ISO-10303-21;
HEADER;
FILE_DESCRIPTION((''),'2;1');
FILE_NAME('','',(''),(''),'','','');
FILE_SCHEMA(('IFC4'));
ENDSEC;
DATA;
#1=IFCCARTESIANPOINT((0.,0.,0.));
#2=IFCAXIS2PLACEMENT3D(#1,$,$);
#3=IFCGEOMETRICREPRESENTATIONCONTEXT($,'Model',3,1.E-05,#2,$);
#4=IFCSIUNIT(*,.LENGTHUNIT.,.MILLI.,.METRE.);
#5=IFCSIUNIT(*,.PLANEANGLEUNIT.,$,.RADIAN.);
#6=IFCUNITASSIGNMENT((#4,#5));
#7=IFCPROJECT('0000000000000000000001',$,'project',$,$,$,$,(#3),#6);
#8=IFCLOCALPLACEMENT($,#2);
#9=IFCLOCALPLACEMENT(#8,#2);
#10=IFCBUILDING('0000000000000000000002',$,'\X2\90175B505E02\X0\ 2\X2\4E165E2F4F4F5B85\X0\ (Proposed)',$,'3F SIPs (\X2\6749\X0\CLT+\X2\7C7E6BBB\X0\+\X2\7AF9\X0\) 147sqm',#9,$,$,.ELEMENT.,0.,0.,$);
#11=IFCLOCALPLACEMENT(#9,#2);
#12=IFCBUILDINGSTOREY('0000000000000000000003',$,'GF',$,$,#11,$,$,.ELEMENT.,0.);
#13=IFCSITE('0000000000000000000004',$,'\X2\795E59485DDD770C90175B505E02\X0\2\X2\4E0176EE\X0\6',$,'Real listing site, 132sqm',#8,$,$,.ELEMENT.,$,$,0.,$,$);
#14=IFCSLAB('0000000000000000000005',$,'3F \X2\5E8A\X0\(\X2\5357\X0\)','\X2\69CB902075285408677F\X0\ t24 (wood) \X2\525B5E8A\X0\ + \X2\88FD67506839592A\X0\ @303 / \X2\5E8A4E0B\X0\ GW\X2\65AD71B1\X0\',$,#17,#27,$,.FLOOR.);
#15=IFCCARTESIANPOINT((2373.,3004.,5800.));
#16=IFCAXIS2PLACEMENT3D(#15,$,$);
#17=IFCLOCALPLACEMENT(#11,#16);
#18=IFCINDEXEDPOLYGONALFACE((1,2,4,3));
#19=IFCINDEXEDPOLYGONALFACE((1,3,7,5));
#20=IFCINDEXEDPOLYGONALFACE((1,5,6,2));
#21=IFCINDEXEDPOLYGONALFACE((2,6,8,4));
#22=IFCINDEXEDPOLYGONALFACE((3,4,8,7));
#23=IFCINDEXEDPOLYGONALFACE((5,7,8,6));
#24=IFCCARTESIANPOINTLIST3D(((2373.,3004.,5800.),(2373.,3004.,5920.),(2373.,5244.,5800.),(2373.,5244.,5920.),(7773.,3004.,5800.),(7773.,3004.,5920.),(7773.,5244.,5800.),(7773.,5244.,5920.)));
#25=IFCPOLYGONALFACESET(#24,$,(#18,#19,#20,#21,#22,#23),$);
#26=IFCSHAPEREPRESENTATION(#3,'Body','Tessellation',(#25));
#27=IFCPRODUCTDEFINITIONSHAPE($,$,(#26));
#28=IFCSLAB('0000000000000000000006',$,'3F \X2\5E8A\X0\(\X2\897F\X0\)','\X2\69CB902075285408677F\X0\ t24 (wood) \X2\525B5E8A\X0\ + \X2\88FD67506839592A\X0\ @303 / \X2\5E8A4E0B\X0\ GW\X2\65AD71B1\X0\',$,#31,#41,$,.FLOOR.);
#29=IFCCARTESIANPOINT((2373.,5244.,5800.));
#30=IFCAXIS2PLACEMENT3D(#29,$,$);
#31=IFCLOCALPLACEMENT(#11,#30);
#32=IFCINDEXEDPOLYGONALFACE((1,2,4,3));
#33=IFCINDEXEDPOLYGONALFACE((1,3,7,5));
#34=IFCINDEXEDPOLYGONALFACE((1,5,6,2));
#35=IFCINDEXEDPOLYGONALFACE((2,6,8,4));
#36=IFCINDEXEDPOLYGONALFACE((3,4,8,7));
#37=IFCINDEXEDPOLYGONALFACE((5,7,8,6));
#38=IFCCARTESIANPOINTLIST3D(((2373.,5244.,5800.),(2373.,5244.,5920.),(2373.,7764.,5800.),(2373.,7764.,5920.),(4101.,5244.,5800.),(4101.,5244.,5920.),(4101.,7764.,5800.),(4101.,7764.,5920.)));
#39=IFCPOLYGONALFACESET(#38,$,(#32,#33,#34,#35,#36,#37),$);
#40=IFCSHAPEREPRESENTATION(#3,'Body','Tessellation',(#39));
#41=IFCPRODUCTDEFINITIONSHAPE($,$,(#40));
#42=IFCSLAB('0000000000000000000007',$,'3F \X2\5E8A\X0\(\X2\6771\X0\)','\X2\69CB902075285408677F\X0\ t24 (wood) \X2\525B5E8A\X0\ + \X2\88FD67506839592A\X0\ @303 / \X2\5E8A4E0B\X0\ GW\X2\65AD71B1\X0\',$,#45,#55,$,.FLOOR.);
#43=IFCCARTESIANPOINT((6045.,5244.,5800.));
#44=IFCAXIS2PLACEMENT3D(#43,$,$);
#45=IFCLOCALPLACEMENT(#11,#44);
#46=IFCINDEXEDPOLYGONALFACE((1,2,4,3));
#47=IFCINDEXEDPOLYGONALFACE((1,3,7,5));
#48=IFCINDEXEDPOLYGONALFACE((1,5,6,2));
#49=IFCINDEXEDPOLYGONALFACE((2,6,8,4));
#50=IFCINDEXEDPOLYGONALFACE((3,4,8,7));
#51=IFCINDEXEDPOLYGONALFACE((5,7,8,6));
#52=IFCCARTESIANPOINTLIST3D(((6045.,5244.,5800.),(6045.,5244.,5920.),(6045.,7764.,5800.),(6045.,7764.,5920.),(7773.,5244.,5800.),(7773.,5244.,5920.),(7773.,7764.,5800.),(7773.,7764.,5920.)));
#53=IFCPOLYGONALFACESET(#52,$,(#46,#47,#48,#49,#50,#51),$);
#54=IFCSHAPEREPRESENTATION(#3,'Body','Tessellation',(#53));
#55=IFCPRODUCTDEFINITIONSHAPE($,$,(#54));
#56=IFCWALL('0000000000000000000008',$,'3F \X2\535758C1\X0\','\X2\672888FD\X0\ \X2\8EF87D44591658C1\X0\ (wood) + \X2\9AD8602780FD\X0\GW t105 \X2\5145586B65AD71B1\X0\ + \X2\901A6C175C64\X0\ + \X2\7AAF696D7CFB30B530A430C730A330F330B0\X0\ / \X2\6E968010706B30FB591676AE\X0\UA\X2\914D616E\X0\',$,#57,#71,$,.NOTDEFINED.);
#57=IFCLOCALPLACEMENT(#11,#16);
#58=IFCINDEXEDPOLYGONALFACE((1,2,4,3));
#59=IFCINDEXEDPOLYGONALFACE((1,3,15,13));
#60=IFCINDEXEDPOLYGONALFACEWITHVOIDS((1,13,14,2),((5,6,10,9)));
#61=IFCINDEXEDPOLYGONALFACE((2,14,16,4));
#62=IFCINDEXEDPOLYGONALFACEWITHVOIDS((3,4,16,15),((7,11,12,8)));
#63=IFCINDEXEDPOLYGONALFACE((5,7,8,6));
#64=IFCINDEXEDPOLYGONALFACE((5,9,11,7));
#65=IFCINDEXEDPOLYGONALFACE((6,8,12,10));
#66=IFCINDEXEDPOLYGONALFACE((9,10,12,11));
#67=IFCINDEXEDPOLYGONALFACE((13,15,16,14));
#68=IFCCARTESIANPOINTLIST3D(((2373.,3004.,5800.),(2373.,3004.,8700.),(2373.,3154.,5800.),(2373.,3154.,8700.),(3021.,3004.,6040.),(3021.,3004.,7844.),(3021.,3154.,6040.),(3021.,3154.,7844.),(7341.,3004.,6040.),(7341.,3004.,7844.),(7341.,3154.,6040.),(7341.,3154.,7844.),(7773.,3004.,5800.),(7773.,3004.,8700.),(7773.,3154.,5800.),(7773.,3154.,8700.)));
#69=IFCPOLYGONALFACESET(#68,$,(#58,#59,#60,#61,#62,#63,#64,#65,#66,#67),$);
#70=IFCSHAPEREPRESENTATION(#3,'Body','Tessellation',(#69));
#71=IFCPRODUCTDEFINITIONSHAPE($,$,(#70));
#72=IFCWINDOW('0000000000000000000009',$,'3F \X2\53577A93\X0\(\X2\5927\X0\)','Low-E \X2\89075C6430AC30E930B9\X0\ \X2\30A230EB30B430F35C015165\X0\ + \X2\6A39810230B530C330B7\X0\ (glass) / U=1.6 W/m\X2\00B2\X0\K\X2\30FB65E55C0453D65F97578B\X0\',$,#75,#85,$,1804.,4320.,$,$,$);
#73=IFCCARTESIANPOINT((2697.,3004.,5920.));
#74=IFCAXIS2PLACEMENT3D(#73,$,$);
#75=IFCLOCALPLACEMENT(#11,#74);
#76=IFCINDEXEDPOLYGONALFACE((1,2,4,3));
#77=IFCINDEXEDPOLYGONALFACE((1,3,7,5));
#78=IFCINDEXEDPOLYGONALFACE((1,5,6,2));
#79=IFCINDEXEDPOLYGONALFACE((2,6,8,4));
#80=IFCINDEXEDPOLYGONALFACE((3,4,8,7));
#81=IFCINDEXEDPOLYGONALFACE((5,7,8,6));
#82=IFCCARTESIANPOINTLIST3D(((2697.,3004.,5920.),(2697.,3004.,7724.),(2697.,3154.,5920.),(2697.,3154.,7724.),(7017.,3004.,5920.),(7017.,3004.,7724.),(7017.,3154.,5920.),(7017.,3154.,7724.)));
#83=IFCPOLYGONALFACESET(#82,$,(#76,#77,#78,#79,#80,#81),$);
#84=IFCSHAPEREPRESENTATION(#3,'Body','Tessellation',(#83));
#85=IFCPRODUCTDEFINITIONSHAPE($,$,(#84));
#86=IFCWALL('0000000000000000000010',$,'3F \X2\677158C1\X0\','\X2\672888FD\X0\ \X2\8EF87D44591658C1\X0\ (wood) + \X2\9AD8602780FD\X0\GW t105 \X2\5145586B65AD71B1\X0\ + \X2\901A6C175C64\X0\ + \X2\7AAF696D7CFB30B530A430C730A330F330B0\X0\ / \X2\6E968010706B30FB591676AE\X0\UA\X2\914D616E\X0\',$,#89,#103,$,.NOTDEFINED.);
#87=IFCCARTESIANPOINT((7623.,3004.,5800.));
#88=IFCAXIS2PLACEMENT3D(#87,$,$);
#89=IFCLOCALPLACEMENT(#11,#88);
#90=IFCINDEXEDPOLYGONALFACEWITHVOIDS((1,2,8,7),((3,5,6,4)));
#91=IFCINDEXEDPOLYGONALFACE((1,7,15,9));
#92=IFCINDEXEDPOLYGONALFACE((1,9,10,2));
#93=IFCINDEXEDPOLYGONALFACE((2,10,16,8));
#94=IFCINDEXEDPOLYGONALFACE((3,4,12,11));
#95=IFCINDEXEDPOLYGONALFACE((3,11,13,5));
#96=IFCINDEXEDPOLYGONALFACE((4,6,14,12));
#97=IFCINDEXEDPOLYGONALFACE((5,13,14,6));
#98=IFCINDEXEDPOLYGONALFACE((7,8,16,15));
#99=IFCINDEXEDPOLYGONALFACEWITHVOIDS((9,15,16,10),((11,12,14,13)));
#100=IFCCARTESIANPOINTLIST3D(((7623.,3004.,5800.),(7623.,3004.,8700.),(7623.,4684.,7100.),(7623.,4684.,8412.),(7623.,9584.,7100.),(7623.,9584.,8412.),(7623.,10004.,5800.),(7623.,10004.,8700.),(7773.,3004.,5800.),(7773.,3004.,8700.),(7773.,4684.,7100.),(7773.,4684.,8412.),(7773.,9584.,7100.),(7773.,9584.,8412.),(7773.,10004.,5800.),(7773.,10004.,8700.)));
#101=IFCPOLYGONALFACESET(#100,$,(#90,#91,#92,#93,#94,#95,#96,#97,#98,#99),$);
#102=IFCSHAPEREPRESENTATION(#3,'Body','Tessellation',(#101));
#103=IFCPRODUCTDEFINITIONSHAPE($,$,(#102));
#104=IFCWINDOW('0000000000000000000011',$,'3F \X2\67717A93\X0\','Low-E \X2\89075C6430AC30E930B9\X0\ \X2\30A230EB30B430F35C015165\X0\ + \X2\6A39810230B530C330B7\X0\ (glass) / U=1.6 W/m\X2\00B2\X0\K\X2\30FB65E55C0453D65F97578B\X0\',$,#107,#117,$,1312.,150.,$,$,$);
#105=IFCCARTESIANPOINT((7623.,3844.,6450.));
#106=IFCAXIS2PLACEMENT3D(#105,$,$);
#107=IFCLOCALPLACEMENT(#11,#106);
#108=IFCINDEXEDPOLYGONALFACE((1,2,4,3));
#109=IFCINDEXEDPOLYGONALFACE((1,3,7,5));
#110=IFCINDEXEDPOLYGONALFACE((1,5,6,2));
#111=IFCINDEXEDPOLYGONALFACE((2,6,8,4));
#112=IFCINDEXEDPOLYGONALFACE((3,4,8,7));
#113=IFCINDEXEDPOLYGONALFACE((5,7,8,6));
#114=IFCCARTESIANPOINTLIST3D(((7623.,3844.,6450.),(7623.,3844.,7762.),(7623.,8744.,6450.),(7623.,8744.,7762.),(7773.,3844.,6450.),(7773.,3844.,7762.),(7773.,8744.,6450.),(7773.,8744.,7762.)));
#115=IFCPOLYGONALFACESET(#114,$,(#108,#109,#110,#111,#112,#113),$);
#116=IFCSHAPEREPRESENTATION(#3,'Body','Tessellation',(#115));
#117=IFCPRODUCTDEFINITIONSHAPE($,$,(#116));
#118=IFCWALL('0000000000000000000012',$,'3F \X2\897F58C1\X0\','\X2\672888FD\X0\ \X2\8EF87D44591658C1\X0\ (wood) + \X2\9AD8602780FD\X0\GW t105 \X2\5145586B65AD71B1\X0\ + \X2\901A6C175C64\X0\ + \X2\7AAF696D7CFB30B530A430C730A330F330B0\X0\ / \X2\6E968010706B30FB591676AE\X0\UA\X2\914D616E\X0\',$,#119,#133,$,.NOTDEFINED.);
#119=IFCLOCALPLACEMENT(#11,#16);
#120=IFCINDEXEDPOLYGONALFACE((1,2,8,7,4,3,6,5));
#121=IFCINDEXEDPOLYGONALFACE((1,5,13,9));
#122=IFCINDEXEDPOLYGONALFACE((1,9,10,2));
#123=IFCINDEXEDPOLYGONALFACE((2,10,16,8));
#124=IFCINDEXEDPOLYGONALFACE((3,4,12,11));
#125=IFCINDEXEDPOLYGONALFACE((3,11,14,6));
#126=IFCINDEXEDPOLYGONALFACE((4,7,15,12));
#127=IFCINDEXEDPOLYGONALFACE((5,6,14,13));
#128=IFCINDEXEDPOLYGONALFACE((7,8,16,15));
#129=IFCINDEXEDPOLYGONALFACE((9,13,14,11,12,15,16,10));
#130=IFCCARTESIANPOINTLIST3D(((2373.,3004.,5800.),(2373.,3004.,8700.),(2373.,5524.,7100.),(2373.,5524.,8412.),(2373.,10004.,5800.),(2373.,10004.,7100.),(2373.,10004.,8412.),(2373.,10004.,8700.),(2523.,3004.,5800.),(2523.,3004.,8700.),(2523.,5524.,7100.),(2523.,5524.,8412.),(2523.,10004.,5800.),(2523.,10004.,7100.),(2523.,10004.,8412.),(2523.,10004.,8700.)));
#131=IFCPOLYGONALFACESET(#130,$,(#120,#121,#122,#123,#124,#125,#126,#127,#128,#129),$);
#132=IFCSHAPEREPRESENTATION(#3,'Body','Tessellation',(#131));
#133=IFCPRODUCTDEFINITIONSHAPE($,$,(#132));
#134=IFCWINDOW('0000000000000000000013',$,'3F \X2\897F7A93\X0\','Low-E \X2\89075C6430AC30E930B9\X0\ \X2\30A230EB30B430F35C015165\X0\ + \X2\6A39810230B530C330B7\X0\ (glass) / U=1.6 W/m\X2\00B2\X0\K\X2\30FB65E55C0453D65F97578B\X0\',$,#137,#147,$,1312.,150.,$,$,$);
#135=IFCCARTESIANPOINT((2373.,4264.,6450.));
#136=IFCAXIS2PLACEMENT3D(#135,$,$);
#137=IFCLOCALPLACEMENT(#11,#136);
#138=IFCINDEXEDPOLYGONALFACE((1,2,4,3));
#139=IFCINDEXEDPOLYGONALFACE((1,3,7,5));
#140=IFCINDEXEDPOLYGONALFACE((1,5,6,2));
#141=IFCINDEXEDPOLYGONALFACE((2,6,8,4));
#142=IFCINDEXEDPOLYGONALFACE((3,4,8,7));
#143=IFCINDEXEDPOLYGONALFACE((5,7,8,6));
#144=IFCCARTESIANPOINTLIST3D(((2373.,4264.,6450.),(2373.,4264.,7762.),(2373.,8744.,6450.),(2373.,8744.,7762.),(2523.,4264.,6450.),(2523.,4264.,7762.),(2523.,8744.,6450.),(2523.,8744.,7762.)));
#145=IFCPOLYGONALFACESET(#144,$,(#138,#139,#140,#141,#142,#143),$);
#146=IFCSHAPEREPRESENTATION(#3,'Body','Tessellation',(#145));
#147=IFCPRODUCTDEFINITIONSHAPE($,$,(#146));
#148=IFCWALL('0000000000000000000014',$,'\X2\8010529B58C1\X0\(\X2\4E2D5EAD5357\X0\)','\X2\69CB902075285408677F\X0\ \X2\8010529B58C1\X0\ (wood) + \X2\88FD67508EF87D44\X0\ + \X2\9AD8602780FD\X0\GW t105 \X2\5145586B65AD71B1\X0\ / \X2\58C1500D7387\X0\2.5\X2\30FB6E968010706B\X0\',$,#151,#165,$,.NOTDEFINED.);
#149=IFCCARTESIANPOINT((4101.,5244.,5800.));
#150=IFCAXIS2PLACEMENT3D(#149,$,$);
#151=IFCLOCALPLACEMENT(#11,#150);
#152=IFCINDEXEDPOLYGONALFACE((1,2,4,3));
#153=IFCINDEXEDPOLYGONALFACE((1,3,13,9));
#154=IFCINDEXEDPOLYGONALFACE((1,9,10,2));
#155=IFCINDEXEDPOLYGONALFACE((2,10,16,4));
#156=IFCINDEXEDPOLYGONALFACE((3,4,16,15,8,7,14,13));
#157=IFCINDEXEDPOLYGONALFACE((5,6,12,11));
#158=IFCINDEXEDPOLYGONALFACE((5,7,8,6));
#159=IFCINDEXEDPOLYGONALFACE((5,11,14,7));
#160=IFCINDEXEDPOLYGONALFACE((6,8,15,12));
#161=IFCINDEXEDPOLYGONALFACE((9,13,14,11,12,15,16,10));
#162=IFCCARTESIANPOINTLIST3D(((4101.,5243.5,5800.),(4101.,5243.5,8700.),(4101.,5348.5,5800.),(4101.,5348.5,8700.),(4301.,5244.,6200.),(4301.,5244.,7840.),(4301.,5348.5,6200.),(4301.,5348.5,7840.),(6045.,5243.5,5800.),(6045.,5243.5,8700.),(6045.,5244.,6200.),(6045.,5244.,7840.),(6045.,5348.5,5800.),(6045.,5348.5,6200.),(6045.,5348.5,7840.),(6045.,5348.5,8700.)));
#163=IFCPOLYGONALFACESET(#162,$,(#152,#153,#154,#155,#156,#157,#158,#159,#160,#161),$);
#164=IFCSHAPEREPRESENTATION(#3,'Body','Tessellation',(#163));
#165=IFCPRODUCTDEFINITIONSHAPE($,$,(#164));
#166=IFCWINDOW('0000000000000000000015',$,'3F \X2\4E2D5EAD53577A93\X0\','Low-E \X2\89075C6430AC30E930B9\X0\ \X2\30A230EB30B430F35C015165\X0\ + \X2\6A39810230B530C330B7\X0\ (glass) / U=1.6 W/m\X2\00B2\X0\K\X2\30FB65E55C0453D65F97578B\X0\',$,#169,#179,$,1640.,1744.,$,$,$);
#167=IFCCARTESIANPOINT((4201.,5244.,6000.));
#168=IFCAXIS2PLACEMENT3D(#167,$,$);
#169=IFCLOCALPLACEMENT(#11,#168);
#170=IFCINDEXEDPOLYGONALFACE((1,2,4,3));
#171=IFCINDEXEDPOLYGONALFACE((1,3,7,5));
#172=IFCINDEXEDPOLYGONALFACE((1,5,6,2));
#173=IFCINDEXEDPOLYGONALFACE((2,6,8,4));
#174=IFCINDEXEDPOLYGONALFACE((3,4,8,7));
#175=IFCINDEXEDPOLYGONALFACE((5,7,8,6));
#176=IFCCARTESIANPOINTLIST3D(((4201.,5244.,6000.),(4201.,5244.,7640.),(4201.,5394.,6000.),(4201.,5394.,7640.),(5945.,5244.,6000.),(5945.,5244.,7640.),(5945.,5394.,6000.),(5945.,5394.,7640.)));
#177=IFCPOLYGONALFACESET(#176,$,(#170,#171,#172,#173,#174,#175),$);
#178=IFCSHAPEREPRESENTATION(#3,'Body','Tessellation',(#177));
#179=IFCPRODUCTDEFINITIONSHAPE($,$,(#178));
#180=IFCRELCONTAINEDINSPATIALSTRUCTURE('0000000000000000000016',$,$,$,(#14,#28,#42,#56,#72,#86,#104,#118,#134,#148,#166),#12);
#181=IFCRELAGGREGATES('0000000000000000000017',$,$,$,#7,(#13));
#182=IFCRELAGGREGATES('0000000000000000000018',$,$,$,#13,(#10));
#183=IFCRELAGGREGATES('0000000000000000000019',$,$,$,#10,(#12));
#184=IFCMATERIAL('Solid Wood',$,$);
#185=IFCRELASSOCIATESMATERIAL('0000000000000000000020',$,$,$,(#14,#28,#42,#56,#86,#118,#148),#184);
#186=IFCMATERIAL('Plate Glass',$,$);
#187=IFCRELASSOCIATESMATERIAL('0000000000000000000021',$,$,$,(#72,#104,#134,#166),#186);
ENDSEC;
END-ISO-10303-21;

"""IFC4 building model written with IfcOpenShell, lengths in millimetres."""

from ifc_helpers import new_model, si_unit, frame, frame_2d, origin, place, context, project, spatial, rectangle, extrude, material, element, fill, save


model = new_model("IFC4")

# Units and contexts
model_context = context("Model", 3, precision=1e-05, world=origin())
ifc_project = project(units=[si_unit("LENGTHUNIT", "METRE", prefix="MILLI"), si_unit("PLANEANGLEUNIT", "RADIAN")], contexts=[model_context])

# Site, building, storey
site_placement = place(None, origin())
site = spatial("IfcSite", under=ifc_project, at=site_placement, Name="神奈川県逗子市2丁目6", ObjectType="Real listing site, 132sqm", CompositionType="ELEMENT", RefElevation=0.0)
building_placement = place(site_placement, origin())
building = spatial("IfcBuilding", under=site, at=building_placement, Name="逗子市 2世帯住宅 (Proposed)", ObjectType="3F SIPs (杉CLT+籾殻+竹) 147sqm", CompositionType="ELEMENT", ElevationOfRefHeight=0.0, ElevationOfTerrain=0.0)
storey_placement = place(building_placement, origin())
storey = spatial("IfcBuildingStorey", under=building, at=storey_placement, Name="GF", CompositionType="ELEMENT", Elevation=0.0)

# Slabs
ifc_material_1 = material(Name="Solid Wood")
slab_1_placement = place(storey_placement, frame((2373.0, 3004.0, 5800.0)))
element("IfcSlab", 1, at=slab_1_placement, inside=storey, material=ifc_material_1, Name="3F 床(南)", Description="構造用合板 t24 (wood) 剛床 + 製材根太 @303 / 床下 GW断熱", PredefinedType="FLOOR", context=model_context, shape_type="SweptSolid", body=[
    extrude(rectangle(XDim=5400.0, YDim=2240.0, at=frame_2d((2700.0, 1120.0))), frame((2373.0, 3004.0, 5800.0)), (0.0, 0.0, 1.0), 120.0),
])
slab_2_placement = place(storey_placement, frame((2373.0, 5244.0, 5800.0)))
element("IfcSlab", 2, at=slab_2_placement, inside=storey, material=ifc_material_1, Name="3F 床(西)", Description="構造用合板 t24 (wood) 剛床 + 製材根太 @303 / 床下 GW断熱", PredefinedType="FLOOR", context=model_context, shape_type="SweptSolid", body=[
    extrude(rectangle(XDim=1728.0, YDim=2520.0, at=frame_2d((864.0, 1260.0))), frame((2373.0, 5244.0, 5800.0)), (0.0, 0.0, 1.0), 120.0),
])
slab_3_placement = place(storey_placement, frame((6045.0, 5244.0, 5800.0)))
element("IfcSlab", 3, at=slab_3_placement, inside=storey, material=ifc_material_1, Name="3F 床(東)", Description="構造用合板 t24 (wood) 剛床 + 製材根太 @303 / 床下 GW断熱", PredefinedType="FLOOR", context=model_context, shape_type="SweptSolid", body=[
    extrude(rectangle(XDim=1728.0, YDim=2520.0, at=frame_2d((864.0, 1260.0))), frame((6045.0, 5244.0, 5800.0)), (0.0, 0.0, 1.0), 120.0),
])

# Walls, openings, windows
wall_1_placement = place(storey_placement, frame((2373.0, 3004.0, 5800.0)))
wall_1 = element("IfcWall", 4, at=wall_1_placement, inside=storey, material=ifc_material_1, Name="3F 南壁", Description="木製 軸組外壁 (wood) + 高性能GW t105 充填断熱 + 通気層 + 窯業系サイディング / 準耐火・外皮UA配慮", PredefinedType="NOTDEFINED", context=model_context, shape_type="SweptSolid", body=[
    extrude(rectangle(XDim=5400.0, YDim=150.0, at=frame_2d((2700.0, 75.0))), frame((2373.0, 3004.0, 5800.0)), (0.0, 0.0, 1.0), 2900.0),
])
opening_1_placement = place(storey_placement, frame((2697.0, 3004.0, 5920.0)))
opening_1 = element("IfcOpeningElement", 5, at=opening_1_placement, cuts=wall_1, PredefinedType="NOTDEFINED", context=model_context, shape_type="SweptSolid", body=[
    extrude(rectangle(XDim=4320.0, YDim=150.0, at=frame_2d((2160.0, 75.0))), frame((2697.0, 3004.0, 5920.0)), (0.0, 0.0, 1.0), 1804.0),
])
ifc_material_2 = material(Name="Plate Glass")
window_1_placement = place(storey_placement, frame((2697.0, 3004.0, 5920.0)))
window_1 = element("IfcWindow", 6, at=window_1_placement, inside=storey, material=ifc_material_2, Name="3F 南窓(大)", Description="Low-E 複層ガラス アルゴン封入 + 樹脂サッシ (glass) / U=1.6 W/m²K・日射取得型", OverallHeight=1804.0, OverallWidth=4320.0, context=model_context, shape_type="SweptSolid", body=[
    extrude(rectangle(XDim=4320.0, YDim=150.0, at=frame_2d((2160.0, 75.0))), frame((2697.0, 3004.0, 5920.0)), (0.0, 0.0, 1.0), 1804.0),
])
fill(opening_1, window_1)
wall_2_placement = place(storey_placement, frame((7623.0, 3004.0, 5800.0)))
wall_2 = element("IfcWall", 7, at=wall_2_placement, inside=storey, material=ifc_material_1, Name="3F 東壁", Description="木製 軸組外壁 (wood) + 高性能GW t105 充填断熱 + 通気層 + 窯業系サイディング / 準耐火・外皮UA配慮", PredefinedType="NOTDEFINED", context=model_context, shape_type="SweptSolid", body=[
    extrude(rectangle(XDim=150.0, YDim=7000.0, at=frame_2d((75.0, 3500.0))), frame((7623.0, 3004.0, 5800.0)), (0.0, 0.0, 1.0), 2900.0),
])
opening_2_placement = place(storey_placement, frame((7623.0, 3844.0, 6450.0)))
opening_2 = element("IfcOpeningElement", 8, at=opening_2_placement, cuts=wall_2, PredefinedType="NOTDEFINED", context=model_context, shape_type="SweptSolid", body=[
    extrude(rectangle(XDim=150.0, YDim=4900.0, at=frame_2d((75.0, 2450.0))), frame((7623.0, 3844.0, 6450.0)), (0.0, 0.0, 1.0), 1312.0),
])
window_2_placement = place(storey_placement, frame((7623.0, 3844.0, 6450.0)))
window_2 = element("IfcWindow", 9, at=window_2_placement, inside=storey, material=ifc_material_2, Name="3F 東窓", Description="Low-E 複層ガラス アルゴン封入 + 樹脂サッシ (glass) / U=1.6 W/m²K・日射取得型", OverallHeight=1312.0, OverallWidth=150.0, context=model_context, shape_type="SweptSolid", body=[
    extrude(rectangle(XDim=150.0, YDim=4900.0, at=frame_2d((75.0, 2450.0))), frame((7623.0, 3844.0, 6450.0)), (0.0, 0.0, 1.0), 1312.0),
])
fill(opening_2, window_2)
wall_3_placement = place(storey_placement, frame((2373.0, 3004.0, 5800.0)))
wall_3 = element("IfcWall", 10, at=wall_3_placement, inside=storey, material=ifc_material_1, Name="3F 西壁", Description="木製 軸組外壁 (wood) + 高性能GW t105 充填断熱 + 通気層 + 窯業系サイディング / 準耐火・外皮UA配慮", PredefinedType="NOTDEFINED", context=model_context, shape_type="SweptSolid", body=[
    extrude(rectangle(XDim=150.0, YDim=7000.0, at=frame_2d((75.0, 3500.0))), frame((2373.0, 3004.0, 5800.0)), (0.0, 0.0, 1.0), 2900.0),
])
opening_3_placement = place(storey_placement, frame((2373.0, 4264.0, 6450.0)))
opening_3 = element("IfcOpeningElement", 11, at=opening_3_placement, cuts=wall_3, PredefinedType="NOTDEFINED", context=model_context, shape_type="SweptSolid", body=[
    extrude(rectangle(XDim=150.0, YDim=4480.0, at=frame_2d((75.0, 2240.0))), frame((2373.0, 4264.0, 6450.0)), (0.0, 0.0, 1.0), 1312.0),
])
window_3_placement = place(storey_placement, frame((2373.0, 4264.0, 6450.0)))
window_3 = element("IfcWindow", 12, at=window_3_placement, inside=storey, material=ifc_material_2, Name="3F 西窓", Description="Low-E 複層ガラス アルゴン封入 + 樹脂サッシ (glass) / U=1.6 W/m²K・日射取得型", OverallHeight=1312.0, OverallWidth=150.0, context=model_context, shape_type="SweptSolid", body=[
    extrude(rectangle(XDim=150.0, YDim=4480.0, at=frame_2d((75.0, 2240.0))), frame((2373.0, 4264.0, 6450.0)), (0.0, 0.0, 1.0), 1312.0),
])
fill(opening_3, window_3)
wall_4_placement = place(storey_placement, frame((4101.0, 5244.0, 5800.0)))
wall_4 = element("IfcWall", 13, at=wall_4_placement, inside=storey, material=ifc_material_1, Name="耐力壁(中庭南)", Description="構造用合板 耐力壁 (wood) + 製材軸組 + 高性能GW t105 充填断熱 / 壁倍率2.5・準耐火", PredefinedType="NOTDEFINED", context=model_context, shape_type="SweptSolid", body=[
    extrude(rectangle(XDim=1944.0, YDim=105.0, at=frame_2d((972.0, 52.0))), frame((4101.0, 5244.0, 5800.0)), (0.0, 0.0, 1.0), 2900.0),
])
opening_4_placement = place(storey_placement, frame((4201.0, 5244.0, 6000.0)))
opening_4 = element("IfcOpeningElement", 14, at=opening_4_placement, cuts=wall_4, PredefinedType="NOTDEFINED", context=model_context, shape_type="SweptSolid", body=[
    extrude(rectangle(XDim=1744.0, YDim=150.0, at=frame_2d((872.0, 75.0))), frame((4201.0, 5244.0, 6000.0)), (0.0, 0.0, 1.0), 1640.0),
])
window_4_placement = place(storey_placement, frame((4201.0, 5244.0, 6000.0)))
window_4 = element("IfcWindow", 15, at=window_4_placement, inside=storey, material=ifc_material_2, Name="3F 中庭南窓", Description="Low-E 複層ガラス アルゴン封入 + 樹脂サッシ (glass) / U=1.6 W/m²K・日射取得型", OverallHeight=1640.0, OverallWidth=1744.0, context=model_context, shape_type="SweptSolid", body=[
    extrude(rectangle(XDim=1744.0, YDim=150.0, at=frame_2d((872.0, 75.0))), frame((4201.0, 5244.0, 6000.0)), (0.0, 0.0, 1.0), 1640.0),
])
fill(opening_4, window_4)

save(model, "model.ifc")
